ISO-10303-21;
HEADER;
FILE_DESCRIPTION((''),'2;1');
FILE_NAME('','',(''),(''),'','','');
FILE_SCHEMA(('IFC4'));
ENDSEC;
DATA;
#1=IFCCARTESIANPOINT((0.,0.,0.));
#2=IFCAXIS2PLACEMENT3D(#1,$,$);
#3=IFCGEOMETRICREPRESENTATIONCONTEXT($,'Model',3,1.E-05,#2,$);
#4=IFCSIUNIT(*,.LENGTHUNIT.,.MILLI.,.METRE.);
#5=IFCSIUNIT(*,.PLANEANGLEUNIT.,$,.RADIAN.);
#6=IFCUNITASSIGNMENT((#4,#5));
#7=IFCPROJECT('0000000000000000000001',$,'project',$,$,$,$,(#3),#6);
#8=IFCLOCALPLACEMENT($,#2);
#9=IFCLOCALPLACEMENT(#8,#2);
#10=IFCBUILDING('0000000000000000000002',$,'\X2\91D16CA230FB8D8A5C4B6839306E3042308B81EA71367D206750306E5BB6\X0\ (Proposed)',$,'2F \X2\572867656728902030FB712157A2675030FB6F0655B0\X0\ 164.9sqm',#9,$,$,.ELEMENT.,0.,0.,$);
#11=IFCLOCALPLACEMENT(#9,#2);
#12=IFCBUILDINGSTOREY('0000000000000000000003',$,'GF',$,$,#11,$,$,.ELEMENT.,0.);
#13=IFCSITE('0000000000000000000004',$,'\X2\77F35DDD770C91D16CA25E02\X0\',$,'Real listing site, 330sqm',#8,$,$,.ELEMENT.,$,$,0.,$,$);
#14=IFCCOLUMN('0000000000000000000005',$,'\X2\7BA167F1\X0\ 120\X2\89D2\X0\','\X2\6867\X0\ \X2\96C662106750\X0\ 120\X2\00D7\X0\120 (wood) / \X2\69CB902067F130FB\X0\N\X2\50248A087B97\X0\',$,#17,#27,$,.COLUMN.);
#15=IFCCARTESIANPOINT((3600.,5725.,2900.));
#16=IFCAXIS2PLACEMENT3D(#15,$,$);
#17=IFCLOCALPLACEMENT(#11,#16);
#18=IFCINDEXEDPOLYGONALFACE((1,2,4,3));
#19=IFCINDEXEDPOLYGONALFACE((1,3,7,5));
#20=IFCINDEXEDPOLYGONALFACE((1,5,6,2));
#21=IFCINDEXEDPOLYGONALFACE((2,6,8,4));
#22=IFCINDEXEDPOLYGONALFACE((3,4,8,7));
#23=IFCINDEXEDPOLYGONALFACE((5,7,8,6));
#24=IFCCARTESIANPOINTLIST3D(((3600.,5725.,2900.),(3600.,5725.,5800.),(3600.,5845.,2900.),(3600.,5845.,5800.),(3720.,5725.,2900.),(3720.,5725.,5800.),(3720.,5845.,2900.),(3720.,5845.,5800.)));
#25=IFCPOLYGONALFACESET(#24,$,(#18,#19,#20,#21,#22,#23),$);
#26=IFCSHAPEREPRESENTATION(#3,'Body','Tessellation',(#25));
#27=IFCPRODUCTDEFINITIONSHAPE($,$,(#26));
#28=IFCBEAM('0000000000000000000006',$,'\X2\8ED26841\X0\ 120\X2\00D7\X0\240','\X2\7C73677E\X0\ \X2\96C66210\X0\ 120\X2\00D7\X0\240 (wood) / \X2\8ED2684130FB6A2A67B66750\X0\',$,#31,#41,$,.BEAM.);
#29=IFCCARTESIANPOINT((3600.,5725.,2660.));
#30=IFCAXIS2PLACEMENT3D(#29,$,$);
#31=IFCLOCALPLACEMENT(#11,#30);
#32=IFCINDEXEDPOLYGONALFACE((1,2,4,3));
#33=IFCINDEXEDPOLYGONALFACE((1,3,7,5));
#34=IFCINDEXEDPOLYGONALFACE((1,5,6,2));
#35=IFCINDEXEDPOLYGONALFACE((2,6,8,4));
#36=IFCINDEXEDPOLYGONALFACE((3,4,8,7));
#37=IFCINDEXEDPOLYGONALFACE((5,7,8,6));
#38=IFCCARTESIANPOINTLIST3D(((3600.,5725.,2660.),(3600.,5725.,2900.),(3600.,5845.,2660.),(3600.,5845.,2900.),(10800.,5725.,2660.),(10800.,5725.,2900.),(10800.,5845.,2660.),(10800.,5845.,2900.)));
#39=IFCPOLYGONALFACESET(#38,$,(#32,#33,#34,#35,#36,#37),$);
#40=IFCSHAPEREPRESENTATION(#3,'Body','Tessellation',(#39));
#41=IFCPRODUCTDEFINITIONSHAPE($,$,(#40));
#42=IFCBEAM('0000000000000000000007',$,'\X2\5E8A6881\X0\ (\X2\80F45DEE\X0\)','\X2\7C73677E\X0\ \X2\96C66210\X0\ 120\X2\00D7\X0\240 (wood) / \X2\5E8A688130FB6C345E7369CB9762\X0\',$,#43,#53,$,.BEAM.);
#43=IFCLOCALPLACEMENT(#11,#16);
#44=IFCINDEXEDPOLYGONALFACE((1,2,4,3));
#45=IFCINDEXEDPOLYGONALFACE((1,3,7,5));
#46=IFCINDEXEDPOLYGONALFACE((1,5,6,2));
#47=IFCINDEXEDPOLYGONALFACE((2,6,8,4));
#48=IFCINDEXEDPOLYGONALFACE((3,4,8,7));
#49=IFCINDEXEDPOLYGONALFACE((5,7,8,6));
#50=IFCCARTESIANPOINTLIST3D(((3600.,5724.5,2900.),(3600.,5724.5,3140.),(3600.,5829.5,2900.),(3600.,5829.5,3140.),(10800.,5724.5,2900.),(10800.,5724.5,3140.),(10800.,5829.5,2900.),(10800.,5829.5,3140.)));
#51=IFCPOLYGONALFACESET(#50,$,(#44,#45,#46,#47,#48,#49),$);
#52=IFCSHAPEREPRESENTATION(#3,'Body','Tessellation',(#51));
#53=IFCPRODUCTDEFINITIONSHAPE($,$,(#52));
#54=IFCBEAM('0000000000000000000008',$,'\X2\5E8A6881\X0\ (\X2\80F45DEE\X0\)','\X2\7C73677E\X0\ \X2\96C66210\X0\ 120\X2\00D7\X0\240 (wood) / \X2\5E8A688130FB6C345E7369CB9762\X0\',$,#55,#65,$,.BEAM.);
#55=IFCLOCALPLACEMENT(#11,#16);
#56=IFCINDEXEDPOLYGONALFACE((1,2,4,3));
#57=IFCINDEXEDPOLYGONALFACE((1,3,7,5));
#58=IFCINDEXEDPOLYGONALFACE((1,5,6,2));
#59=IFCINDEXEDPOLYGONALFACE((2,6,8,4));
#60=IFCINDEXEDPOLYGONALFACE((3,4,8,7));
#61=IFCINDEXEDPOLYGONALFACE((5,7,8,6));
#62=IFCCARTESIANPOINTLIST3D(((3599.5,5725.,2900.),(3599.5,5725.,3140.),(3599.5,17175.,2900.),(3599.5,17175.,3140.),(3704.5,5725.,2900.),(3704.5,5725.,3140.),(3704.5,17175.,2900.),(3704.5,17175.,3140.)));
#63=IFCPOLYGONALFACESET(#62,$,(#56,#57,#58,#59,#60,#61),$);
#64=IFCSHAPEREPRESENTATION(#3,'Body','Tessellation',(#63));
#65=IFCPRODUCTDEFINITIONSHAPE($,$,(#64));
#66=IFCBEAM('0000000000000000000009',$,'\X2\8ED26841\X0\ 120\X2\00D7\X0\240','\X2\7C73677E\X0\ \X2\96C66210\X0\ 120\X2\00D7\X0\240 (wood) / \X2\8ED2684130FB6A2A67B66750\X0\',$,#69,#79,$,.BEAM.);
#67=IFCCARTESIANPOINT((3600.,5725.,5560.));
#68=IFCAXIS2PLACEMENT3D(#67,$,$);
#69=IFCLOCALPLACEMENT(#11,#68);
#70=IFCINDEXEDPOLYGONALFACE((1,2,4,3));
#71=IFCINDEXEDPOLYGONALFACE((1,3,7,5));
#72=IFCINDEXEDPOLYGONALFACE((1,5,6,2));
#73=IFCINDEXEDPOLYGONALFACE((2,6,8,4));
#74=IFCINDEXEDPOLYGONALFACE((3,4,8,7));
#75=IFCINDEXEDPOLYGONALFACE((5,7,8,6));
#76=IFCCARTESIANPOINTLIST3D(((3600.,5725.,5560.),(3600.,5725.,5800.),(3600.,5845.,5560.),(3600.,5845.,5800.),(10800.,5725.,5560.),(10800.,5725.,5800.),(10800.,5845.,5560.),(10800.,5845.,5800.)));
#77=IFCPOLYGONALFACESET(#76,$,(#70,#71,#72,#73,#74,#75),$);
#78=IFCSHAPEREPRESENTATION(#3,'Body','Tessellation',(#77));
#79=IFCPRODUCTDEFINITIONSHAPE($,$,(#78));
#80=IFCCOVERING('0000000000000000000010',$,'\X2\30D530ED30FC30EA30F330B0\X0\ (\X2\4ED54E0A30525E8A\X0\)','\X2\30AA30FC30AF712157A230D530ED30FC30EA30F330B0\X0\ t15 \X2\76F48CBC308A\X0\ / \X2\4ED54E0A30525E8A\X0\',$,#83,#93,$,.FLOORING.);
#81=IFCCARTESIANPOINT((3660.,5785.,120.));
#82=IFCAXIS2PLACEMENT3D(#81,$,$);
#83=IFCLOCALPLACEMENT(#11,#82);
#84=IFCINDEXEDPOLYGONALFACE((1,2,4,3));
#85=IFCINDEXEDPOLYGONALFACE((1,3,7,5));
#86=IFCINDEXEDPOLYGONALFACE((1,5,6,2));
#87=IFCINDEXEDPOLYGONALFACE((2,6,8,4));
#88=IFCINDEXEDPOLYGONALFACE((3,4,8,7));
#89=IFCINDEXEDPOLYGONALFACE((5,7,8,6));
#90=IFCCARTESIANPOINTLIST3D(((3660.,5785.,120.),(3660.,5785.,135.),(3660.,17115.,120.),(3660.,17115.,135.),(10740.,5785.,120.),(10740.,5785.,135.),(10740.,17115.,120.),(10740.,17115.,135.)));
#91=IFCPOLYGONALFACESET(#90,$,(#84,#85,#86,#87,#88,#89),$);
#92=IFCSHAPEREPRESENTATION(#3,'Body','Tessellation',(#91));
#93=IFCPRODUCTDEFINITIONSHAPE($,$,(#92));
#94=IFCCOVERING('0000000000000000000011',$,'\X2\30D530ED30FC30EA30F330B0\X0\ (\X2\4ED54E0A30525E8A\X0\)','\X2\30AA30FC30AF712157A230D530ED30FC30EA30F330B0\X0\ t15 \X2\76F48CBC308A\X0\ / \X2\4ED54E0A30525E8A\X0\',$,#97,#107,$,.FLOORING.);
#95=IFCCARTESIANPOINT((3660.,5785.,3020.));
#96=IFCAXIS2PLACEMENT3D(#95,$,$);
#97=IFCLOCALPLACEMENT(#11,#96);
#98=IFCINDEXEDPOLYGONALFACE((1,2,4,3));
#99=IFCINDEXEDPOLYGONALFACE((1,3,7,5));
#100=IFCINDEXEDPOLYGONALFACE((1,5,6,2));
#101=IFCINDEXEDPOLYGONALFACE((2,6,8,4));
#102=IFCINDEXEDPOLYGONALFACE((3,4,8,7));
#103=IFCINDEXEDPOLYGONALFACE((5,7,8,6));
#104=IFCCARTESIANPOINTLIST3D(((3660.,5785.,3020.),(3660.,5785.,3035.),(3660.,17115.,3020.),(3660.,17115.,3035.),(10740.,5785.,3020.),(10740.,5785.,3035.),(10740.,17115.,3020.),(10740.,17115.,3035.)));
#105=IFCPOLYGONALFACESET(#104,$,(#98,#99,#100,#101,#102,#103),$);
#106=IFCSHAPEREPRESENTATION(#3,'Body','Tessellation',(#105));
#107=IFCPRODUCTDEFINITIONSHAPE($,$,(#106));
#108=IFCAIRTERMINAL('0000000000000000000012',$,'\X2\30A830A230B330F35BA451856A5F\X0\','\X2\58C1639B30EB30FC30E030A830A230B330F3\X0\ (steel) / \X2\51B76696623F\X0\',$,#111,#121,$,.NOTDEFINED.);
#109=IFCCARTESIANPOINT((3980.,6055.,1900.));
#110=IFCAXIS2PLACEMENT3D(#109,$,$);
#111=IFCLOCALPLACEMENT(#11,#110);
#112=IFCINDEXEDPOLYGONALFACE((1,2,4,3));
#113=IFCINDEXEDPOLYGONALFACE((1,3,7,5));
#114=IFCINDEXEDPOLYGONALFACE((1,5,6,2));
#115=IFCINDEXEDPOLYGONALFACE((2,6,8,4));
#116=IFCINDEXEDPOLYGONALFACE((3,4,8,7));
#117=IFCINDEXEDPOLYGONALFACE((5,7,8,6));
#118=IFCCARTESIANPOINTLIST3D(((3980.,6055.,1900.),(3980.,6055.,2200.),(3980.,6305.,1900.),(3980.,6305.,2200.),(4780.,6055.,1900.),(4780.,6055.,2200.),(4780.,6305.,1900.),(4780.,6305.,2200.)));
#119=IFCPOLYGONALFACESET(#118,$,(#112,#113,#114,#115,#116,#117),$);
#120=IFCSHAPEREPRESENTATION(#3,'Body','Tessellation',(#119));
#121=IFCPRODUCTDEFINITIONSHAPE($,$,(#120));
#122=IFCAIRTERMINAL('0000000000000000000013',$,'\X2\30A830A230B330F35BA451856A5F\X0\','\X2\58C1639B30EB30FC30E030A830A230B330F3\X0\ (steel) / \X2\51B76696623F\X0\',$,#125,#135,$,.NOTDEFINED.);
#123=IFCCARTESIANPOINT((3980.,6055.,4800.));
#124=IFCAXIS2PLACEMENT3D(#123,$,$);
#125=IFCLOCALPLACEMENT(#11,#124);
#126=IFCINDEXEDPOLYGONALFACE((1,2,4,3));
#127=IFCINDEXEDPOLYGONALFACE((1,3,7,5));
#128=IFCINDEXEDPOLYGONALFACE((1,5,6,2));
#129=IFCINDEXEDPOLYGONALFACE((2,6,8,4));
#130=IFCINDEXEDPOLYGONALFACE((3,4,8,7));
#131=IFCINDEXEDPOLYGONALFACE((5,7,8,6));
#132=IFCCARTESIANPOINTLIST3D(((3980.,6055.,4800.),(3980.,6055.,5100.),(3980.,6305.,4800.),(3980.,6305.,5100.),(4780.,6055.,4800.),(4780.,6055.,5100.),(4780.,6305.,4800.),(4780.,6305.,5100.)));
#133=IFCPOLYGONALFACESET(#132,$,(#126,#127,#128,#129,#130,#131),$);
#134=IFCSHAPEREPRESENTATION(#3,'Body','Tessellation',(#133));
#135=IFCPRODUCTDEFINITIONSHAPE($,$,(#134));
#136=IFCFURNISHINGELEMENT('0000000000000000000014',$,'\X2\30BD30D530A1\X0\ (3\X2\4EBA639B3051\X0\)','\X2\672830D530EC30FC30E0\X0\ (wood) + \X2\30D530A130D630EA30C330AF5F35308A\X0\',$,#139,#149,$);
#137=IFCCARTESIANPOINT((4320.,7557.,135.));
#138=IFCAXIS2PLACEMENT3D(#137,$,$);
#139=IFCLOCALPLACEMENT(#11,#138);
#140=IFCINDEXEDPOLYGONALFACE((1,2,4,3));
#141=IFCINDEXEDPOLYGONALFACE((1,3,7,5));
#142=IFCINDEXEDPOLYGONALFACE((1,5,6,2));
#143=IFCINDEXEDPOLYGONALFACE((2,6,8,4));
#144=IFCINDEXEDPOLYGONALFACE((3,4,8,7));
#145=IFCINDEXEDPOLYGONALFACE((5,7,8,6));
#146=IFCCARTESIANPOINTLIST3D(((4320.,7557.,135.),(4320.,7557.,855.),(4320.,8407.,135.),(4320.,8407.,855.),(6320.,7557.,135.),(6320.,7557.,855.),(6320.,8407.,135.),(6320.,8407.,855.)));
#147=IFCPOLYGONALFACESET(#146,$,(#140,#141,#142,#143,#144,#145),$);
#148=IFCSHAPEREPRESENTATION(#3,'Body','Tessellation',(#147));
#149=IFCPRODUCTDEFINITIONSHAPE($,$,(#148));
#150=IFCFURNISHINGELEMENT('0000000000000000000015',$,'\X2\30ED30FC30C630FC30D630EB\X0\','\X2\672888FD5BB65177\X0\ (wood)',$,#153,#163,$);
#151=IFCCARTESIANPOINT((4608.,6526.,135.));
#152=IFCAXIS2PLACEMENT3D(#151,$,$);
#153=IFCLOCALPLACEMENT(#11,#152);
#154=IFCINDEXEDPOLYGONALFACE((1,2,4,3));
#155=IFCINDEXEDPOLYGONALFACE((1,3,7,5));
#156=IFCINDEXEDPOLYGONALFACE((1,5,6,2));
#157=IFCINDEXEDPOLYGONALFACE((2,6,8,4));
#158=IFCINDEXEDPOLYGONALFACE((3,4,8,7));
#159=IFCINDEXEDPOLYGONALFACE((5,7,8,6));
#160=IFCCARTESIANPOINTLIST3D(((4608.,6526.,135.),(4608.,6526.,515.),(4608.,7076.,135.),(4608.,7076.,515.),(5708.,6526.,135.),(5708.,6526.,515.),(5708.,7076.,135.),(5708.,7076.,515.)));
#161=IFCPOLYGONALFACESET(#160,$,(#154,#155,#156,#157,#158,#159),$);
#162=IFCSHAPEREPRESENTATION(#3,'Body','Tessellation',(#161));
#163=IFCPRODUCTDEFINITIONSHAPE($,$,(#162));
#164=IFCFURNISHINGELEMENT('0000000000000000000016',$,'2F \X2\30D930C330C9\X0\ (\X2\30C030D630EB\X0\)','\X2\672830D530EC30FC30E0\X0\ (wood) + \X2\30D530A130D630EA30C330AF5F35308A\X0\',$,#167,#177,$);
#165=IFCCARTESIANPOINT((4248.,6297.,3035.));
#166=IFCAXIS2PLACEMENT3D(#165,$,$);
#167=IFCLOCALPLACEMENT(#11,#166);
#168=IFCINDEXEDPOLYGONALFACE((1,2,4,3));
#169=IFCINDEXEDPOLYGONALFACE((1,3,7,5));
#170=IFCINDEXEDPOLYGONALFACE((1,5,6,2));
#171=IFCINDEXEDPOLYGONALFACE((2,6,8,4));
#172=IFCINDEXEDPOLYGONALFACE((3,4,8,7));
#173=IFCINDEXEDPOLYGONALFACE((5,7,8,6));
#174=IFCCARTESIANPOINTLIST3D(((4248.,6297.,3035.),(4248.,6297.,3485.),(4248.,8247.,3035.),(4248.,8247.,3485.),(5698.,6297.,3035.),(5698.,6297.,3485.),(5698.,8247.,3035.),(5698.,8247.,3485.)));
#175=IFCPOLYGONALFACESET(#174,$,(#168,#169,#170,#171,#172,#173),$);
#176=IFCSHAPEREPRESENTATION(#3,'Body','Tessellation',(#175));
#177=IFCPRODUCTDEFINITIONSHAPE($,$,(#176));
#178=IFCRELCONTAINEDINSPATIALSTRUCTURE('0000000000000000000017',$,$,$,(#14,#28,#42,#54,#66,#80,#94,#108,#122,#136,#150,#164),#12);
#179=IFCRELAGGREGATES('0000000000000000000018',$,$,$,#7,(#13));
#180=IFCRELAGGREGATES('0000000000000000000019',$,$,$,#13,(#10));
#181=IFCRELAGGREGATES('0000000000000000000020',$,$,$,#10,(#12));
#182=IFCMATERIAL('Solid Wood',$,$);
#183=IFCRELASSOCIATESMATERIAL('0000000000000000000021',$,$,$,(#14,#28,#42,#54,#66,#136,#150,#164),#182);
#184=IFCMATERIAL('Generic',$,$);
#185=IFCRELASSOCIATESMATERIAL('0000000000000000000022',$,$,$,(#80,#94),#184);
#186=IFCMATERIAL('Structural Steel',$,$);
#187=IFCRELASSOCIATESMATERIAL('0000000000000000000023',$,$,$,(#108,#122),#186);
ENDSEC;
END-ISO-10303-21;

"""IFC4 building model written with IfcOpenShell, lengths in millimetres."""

from ifc_helpers import new_model, si_unit, frame, frame_2d, origin, place, context, project, spatial, rectangle, extrude, material, element, save


model = new_model("IFC4")

# Units and contexts
model_context = context("Model", 3, precision=1e-05, world=origin())
ifc_project = project(units=[si_unit("LENGTHUNIT", "METRE", prefix="MILLI"), si_unit("PLANEANGLEUNIT", "RADIAN")], contexts=[model_context])

# Site, building, storey
site_placement = place(None, origin())
site = spatial("IfcSite", under=ifc_project, at=site_placement, Name="石川県金沢市", ObjectType="Real listing site, 330sqm", CompositionType="ELEMENT", RefElevation=0.0)
building_placement = place(site_placement, origin())
building = spatial("IfcBuilding", under=site, at=building_placement, Name="金沢・越屋根のある自然素材の家 (Proposed)", ObjectType="2F 在来木造・無垢材・漆喰 164.9sqm", CompositionType="ELEMENT", ElevationOfRefHeight=0.0, ElevationOfTerrain=0.0)
storey_placement = place(building_placement, origin())
storey = spatial("IfcBuildingStorey", under=building, at=storey_placement, Name="GF", CompositionType="ELEMENT", Elevation=0.0)

# Column
ifc_material_1 = material(Name="Solid Wood")
column_1_placement = place(storey_placement, frame((3600.0, 5725.0, 2900.0)))
element("IfcColumn", 1, at=column_1_placement, inside=storey, material=ifc_material_1, Name="管柱 120角", Description="桧 集成材 120×120 (wood) / 構造柱・N値計算", PredefinedType="COLUMN", context=model_context, shape_type="SweptSolid", body=[
    extrude(rectangle(XDim=120.0, YDim=120.0, at=frame_2d((60.0, 60.0))), frame((3600.0, 5725.0, 2900.0)), (0.0, 0.0, 1.0), 2900.0),
])

# Beams
beam_1_placement = place(storey_placement, frame((3600.0, 5725.0, 2660.0)))
element("IfcBeam", 2, at=beam_1_placement, inside=storey, material=ifc_material_1, Name="軒桁 120×240", Description="米松 集成 120×240 (wood) / 軒桁・横架材", PredefinedType="BEAM", context=model_context, shape_type="SweptSolid", body=[
    extrude(rectangle(XDim=7200.0, YDim=120.0, at=frame_2d((3600.0, 60.0))), frame((3600.0, 5725.0, 2660.0)), (0.0, 0.0, 1.0), 240.0),
])
beam_2_placement = place(storey_placement, frame((3600.0, 5725.0, 2900.0)))
element("IfcBeam", 3, at=beam_2_placement, inside=storey, material=ifc_material_1, Name="床梁 (胴差)", Description="米松 集成 120×240 (wood) / 床梁・水平構面", PredefinedType="BEAM", context=model_context, shape_type="SweptSolid", body=[
    extrude(rectangle(XDim=7200.0, YDim=105.0, at=frame_2d((3600.0, 52.0))), frame((3600.0, 5725.0, 2900.0)), (0.0, 0.0, 1.0), 240.0),
])
beam_3_placement = place(storey_placement, frame((3600.0, 5725.0, 2900.0)))
element("IfcBeam", 4, at=beam_3_placement, inside=storey, material=ifc_material_1, Name="床梁 (胴差)", Description="米松 集成 120×240 (wood) / 床梁・水平構面", PredefinedType="BEAM", context=model_context, shape_type="SweptSolid", body=[
    extrude(rectangle(XDim=105.0, YDim=11450.0, at=frame_2d((52.0, 5725.0))), frame((3600.0, 5725.0, 2900.0)), (0.0, 0.0, 1.0), 240.0),
])
beam_4_placement = place(storey_placement, frame((3600.0, 5725.0, 5560.0)))
element("IfcBeam", 5, at=beam_4_placement, inside=storey, material=ifc_material_1, Name="軒桁 120×240", Description="米松 集成 120×240 (wood) / 軒桁・横架材", PredefinedType="BEAM", context=model_context, shape_type="SweptSolid", body=[
    extrude(rectangle(XDim=7200.0, YDim=120.0, at=frame_2d((3600.0, 60.0))), frame((3600.0, 5725.0, 5560.0)), (0.0, 0.0, 1.0), 240.0),
])

# Coverings
ifc_material_2 = material(Name="Generic")
covering_1_placement = place(storey_placement, frame((3660.0, 5785.0, 120.0)))
element("IfcCovering", 6, at=covering_1_placement, inside=storey, material=ifc_material_2, Name="フローリング (仕上げ床)", Description="オーク無垢フローリング t15 直貼り / 仕上げ床", PredefinedType="FLOORING", context=model_context, shape_type="SweptSolid", body=[
    extrude(rectangle(XDim=7080.0, YDim=11330.0, at=frame_2d((3540.0, 5665.0))), frame((3660.0, 5785.0, 120.0)), (0.0, 0.0, 1.0), 15.0),
])
covering_2_placement = place(storey_placement, frame((3660.0, 5785.0, 3020.0)))
element("IfcCovering", 7, at=covering_2_placement, inside=storey, material=ifc_material_2, Name="フローリング (仕上げ床)", Description="オーク無垢フローリング t15 直貼り / 仕上げ床", PredefinedType="FLOORING", context=model_context, shape_type="SweptSolid", body=[
    extrude(rectangle(XDim=7080.0, YDim=11330.0, at=frame_2d((3540.0, 5665.0))), frame((3660.0, 5785.0, 3020.0)), (0.0, 0.0, 1.0), 15.0),
])

# Air terminals
ifc_material_3 = material(Name="Structural Steel")
air_terminal_1_placement = place(storey_placement, frame((3980.0, 6055.0, 1900.0)))
element("IfcAirTerminal", 8, at=air_terminal_1_placement, inside=storey, material=ifc_material_3, Name="エアコン室内機", Description="壁掛ルームエアコン (steel) / 冷暖房", PredefinedType="NOTDEFINED", context=model_context, shape_type="SweptSolid", body=[
    extrude(rectangle(XDim=800.0, YDim=250.0, at=frame_2d((400.0, 125.0))), frame((3980.0, 6055.0, 1900.0)), (0.0, 0.0, 1.0), 300.0),
])
air_terminal_2_placement = place(storey_placement, frame((3980.0, 6055.0, 4800.0)))
element("IfcAirTerminal", 9, at=air_terminal_2_placement, inside=storey, material=ifc_material_3, Name="エアコン室内機", Description="壁掛ルームエアコン (steel) / 冷暖房", PredefinedType="NOTDEFINED", context=model_context, shape_type="SweptSolid", body=[
    extrude(rectangle(XDim=800.0, YDim=250.0, at=frame_2d((400.0, 125.0))), frame((3980.0, 6055.0, 4800.0)), (0.0, 0.0, 1.0), 300.0),
])

# Furnishing elements
furnishing_1_placement = place(storey_placement, frame((4320.0, 7557.0, 135.0)))
element("IfcFurnishingElement", 10, at=furnishing_1_placement, inside=storey, material=ifc_material_1, Name="ソファ (3人掛け)", Description="木フレーム (wood) + ファブリック張り", context=model_context, shape_type="SweptSolid", body=[
    extrude(rectangle(XDim=2000.0, YDim=850.0, at=frame_2d((1000.0, 425.0))), frame((4320.0, 7557.0, 135.0)), (0.0, 0.0, 1.0), 720.0),
])
furnishing_2_placement = place(storey_placement, frame((4608.0, 6526.0, 135.0)))
element("IfcFurnishingElement", 11, at=furnishing_2_placement, inside=storey, material=ifc_material_1, Name="ローテーブル", Description="木製家具 (wood)", context=model_context, shape_type="SweptSolid", body=[
    extrude(rectangle(XDim=1100.0, YDim=550.0, at=frame_2d((550.0, 275.0))), frame((4608.0, 6526.0, 135.0)), (0.0, 0.0, 1.0), 380.0),
])
furnishing_3_placement = place(storey_placement, frame((4248.0, 6297.0, 3035.0)))
element("IfcFurnishingElement", 12, at=furnishing_3_placement, inside=storey, material=ifc_material_1, Name="2F ベッド (ダブル)", Description="木フレーム (wood) + ファブリック張り", context=model_context, shape_type="SweptSolid", body=[
    extrude(rectangle(XDim=1450.0, YDim=1950.0, at=frame_2d((725.0, 975.0))), frame((4248.0, 6297.0, 3035.0)), (0.0, 0.0, 1.0), 450.0),
])

save(model, "model.ifc")
